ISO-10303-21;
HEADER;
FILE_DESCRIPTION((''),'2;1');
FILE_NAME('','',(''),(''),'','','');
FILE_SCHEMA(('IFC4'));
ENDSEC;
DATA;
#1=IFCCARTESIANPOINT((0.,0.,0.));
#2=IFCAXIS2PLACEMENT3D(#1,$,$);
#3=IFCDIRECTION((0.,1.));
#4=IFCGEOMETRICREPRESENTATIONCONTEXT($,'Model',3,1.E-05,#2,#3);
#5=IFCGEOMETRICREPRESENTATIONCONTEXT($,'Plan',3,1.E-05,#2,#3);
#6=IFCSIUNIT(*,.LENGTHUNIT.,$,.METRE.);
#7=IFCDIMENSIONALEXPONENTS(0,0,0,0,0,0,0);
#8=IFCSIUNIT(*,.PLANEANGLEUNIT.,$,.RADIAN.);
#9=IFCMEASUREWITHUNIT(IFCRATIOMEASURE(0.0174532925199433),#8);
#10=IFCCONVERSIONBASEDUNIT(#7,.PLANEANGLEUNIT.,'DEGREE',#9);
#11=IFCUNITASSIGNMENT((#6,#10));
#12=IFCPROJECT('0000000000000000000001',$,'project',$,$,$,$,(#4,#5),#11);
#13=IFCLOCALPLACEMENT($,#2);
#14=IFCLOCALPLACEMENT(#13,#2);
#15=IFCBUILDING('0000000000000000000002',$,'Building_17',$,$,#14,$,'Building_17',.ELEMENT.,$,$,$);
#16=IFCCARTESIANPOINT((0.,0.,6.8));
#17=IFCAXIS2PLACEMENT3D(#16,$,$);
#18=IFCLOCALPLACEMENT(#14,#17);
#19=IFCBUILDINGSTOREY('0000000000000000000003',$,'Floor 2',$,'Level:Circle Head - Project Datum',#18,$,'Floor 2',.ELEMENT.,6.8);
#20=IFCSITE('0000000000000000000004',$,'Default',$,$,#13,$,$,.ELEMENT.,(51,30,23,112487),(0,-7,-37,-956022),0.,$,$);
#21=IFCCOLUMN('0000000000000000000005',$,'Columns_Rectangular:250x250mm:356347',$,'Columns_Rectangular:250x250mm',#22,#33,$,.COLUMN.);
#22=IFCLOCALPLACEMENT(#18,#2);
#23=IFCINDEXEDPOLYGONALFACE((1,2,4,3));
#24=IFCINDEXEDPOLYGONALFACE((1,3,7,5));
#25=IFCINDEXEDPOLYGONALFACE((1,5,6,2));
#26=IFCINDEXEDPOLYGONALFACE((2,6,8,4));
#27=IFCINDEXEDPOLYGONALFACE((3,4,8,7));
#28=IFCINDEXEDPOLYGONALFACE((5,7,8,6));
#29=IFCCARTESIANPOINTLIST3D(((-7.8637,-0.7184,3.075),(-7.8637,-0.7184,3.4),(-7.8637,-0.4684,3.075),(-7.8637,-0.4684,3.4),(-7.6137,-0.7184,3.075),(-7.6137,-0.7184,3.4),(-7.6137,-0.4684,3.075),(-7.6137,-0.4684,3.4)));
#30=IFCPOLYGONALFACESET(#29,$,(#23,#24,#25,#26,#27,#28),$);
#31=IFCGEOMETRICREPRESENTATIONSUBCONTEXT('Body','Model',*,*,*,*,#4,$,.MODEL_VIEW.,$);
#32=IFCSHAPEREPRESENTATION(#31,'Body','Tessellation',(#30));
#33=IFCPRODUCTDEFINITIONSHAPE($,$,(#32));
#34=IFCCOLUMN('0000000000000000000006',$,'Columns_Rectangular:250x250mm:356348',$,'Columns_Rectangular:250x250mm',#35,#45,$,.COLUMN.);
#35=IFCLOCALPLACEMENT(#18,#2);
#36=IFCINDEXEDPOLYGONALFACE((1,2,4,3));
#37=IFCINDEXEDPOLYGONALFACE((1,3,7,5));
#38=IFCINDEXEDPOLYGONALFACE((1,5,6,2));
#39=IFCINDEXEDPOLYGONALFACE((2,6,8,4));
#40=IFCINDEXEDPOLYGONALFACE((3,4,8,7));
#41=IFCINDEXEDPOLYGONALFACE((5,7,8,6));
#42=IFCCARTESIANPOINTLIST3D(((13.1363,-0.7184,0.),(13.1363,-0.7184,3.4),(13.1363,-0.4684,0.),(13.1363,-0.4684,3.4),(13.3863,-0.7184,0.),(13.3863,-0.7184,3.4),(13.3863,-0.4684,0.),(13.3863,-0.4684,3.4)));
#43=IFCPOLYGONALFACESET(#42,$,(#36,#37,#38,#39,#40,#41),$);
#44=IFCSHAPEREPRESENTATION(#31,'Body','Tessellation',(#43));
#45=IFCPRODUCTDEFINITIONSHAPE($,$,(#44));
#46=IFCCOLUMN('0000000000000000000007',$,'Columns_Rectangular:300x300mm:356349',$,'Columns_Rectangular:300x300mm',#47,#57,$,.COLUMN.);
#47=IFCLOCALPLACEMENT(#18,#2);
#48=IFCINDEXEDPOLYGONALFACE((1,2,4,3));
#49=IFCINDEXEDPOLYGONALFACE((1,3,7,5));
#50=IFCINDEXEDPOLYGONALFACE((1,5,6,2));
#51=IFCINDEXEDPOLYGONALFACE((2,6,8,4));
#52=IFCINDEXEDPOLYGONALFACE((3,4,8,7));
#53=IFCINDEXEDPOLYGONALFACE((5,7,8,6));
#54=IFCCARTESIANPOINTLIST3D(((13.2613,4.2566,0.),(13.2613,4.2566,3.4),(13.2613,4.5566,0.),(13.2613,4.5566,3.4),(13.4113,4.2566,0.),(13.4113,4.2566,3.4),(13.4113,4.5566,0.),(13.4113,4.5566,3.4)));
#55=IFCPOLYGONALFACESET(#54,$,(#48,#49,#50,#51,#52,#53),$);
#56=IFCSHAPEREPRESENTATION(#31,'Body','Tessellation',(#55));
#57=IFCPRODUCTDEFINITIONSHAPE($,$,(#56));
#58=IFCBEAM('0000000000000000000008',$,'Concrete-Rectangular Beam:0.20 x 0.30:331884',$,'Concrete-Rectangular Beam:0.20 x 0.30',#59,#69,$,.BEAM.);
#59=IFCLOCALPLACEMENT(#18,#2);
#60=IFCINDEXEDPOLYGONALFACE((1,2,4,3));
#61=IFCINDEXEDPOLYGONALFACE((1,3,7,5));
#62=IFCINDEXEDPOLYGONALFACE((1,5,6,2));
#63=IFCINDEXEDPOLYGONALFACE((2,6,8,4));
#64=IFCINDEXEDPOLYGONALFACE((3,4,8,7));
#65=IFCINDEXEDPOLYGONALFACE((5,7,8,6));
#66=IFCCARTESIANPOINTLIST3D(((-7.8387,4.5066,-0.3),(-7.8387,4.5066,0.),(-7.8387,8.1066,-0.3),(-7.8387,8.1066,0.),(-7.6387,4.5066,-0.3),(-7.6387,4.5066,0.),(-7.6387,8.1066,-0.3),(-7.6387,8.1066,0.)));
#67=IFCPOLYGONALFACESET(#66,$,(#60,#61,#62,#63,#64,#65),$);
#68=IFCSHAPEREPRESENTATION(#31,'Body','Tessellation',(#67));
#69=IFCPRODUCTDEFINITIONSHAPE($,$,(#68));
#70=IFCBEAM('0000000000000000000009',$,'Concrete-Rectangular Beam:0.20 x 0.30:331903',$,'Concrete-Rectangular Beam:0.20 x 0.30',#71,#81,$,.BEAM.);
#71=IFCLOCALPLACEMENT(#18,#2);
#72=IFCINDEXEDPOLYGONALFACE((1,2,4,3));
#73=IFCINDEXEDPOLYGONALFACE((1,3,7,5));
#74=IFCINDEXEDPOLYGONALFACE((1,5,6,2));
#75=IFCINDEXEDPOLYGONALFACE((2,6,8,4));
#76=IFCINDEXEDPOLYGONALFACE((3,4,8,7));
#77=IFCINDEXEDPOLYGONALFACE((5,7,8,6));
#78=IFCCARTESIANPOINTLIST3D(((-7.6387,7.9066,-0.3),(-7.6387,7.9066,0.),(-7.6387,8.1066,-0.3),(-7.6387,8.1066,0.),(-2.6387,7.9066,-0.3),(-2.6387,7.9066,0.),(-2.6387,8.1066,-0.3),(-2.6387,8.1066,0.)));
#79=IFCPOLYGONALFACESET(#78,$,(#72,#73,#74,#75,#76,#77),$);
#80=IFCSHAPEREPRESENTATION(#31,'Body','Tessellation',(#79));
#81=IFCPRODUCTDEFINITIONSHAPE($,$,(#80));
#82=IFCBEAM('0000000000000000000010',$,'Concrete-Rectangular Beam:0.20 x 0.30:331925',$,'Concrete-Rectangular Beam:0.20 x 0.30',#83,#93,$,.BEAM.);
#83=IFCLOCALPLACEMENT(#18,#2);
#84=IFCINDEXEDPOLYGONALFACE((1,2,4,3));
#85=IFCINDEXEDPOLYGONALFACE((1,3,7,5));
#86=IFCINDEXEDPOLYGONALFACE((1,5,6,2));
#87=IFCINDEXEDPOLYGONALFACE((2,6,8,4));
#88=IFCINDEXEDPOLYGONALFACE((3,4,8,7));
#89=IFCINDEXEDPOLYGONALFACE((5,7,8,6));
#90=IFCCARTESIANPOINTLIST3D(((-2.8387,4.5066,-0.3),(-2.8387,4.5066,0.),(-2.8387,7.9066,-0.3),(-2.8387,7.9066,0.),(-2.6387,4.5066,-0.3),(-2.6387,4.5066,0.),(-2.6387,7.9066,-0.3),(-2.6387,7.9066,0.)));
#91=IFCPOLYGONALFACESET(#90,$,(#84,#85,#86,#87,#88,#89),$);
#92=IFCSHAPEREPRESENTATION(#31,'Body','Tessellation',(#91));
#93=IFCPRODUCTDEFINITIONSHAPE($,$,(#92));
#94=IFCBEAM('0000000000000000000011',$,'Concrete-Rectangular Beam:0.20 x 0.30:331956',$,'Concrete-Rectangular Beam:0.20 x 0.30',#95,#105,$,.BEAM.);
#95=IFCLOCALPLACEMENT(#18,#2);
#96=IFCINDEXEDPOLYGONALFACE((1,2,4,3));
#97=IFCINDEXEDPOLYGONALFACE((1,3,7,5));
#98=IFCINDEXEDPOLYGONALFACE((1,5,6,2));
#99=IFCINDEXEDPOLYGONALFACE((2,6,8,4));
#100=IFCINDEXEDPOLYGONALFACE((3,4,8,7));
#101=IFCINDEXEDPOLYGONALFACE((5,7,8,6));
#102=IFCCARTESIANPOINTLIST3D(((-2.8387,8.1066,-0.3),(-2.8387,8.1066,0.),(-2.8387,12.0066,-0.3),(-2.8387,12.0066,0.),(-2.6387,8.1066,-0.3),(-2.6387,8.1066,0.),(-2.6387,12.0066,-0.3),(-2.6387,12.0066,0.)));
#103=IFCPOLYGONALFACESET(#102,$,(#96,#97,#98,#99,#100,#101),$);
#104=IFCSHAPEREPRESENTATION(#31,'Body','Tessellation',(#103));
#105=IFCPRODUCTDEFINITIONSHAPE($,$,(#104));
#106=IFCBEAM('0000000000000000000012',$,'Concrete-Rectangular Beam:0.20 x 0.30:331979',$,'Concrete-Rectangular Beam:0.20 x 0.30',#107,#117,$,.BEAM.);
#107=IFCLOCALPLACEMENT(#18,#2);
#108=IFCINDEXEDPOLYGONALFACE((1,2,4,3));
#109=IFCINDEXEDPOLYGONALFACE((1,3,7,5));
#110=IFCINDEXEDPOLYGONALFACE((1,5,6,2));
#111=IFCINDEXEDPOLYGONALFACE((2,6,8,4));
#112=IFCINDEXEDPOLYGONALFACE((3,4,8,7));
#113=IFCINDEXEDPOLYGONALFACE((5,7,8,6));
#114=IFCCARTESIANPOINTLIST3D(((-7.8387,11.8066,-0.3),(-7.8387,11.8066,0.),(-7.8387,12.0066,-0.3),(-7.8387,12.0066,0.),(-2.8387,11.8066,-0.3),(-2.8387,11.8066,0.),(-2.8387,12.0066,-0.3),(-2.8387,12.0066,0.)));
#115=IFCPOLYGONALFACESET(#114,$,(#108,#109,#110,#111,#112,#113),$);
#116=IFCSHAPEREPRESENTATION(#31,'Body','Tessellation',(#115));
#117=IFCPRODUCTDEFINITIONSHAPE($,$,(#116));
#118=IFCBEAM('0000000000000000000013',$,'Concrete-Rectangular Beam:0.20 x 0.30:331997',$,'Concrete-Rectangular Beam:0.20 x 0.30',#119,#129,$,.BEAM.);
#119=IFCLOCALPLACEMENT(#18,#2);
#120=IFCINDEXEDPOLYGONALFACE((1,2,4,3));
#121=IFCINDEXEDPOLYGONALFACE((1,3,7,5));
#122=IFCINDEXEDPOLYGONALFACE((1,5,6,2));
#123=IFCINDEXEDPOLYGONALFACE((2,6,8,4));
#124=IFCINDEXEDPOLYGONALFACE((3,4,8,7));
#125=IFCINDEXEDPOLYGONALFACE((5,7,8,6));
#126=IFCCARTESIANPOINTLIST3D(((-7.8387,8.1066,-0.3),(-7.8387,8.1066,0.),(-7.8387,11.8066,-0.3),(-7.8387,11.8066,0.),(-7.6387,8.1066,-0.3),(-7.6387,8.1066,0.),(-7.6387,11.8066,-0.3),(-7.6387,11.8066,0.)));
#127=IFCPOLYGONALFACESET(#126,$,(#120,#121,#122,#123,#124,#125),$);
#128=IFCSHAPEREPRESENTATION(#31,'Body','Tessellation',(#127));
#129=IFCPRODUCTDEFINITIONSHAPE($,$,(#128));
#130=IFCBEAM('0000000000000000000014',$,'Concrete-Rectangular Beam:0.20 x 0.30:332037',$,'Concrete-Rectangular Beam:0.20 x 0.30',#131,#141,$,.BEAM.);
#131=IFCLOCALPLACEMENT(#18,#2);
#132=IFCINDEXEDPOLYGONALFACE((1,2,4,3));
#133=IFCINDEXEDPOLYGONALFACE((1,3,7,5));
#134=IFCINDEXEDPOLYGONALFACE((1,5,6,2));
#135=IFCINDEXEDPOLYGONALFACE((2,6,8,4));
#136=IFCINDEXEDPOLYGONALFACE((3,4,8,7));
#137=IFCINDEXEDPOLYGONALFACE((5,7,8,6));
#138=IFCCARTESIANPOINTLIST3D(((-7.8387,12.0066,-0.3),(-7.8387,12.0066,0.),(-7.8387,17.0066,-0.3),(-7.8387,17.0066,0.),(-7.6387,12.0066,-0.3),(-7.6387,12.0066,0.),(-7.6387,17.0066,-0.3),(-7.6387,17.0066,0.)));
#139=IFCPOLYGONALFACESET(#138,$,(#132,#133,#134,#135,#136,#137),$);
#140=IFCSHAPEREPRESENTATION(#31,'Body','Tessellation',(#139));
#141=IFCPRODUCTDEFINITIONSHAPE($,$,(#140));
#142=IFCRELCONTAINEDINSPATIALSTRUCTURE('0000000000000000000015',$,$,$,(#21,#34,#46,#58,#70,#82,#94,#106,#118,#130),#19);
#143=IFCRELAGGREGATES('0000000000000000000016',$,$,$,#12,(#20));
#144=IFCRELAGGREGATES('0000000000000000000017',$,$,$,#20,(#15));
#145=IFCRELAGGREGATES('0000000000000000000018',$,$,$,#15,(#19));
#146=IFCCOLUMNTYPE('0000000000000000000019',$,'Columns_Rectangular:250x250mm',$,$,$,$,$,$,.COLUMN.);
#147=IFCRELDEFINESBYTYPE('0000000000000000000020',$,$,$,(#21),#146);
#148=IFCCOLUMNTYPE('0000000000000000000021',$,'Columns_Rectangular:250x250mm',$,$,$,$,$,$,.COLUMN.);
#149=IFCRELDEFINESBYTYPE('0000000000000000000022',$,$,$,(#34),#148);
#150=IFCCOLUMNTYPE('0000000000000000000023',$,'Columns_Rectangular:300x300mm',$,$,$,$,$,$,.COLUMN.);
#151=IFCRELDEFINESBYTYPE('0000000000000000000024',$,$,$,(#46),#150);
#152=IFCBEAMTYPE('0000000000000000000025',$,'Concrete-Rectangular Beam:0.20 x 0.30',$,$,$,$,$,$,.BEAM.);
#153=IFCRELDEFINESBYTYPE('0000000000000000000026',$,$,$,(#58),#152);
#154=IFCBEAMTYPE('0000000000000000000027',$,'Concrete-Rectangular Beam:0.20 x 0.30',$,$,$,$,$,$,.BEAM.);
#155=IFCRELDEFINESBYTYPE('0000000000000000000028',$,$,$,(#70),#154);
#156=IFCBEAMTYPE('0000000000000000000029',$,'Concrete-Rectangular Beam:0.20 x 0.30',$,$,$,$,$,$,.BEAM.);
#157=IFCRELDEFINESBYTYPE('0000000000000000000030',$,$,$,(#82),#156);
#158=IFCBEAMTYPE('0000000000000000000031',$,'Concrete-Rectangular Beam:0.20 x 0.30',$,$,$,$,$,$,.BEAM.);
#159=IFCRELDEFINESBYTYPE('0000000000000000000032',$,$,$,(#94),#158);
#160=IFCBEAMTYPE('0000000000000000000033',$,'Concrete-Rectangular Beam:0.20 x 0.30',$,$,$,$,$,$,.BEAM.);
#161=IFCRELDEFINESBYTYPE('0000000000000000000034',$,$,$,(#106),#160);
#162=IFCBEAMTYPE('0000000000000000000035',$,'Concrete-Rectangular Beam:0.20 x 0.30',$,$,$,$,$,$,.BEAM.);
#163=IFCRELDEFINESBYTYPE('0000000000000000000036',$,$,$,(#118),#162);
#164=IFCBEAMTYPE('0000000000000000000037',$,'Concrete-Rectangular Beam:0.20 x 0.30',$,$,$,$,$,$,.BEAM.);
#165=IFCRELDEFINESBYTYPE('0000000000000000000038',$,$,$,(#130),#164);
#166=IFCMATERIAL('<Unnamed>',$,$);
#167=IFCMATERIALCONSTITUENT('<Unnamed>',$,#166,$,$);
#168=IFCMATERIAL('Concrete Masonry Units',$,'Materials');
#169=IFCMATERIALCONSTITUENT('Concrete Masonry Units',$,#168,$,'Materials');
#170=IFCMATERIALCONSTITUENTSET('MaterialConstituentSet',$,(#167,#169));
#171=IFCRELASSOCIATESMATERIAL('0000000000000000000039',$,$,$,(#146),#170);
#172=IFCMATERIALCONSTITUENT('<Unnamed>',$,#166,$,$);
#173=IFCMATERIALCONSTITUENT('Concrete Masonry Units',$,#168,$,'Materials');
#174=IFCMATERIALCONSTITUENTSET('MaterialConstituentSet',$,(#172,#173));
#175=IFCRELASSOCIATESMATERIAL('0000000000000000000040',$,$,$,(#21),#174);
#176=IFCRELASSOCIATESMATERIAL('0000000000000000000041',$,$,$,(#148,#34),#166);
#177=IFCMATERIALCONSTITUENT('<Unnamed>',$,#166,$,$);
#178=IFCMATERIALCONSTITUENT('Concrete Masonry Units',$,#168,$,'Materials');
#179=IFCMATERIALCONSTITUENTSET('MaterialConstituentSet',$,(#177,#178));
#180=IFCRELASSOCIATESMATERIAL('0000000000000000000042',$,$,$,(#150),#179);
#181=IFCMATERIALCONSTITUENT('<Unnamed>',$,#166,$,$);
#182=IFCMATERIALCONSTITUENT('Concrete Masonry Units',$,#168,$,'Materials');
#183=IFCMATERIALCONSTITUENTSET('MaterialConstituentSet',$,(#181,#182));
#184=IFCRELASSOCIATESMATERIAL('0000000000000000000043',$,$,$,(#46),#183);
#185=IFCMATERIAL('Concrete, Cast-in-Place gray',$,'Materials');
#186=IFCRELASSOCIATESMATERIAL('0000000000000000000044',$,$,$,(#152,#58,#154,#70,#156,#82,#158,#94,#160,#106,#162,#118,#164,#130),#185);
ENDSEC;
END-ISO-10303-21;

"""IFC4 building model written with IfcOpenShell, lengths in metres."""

from ifc_helpers import new_model, entity, si_unit, converted_unit, direction, frame, origin, place, context, subcontext, project, spatial, indexed_curve, outline, extrude, source, transform, mapped, material, constituent, constituent_set, type_object, type_shapes, element, save


model = new_model("IFC4")

# Units and contexts
model_context = context("Model", 3, precision=1e-05, world=origin(), true_north=direction((0.0, 1.0)))
plan_context = context("Plan", 3, precision=1e-05, world=origin(), true_north=direction((0.0, 1.0)))
body_context = subcontext(model_context, "Body", "Model", "MODEL_VIEW")
ifc_project = project(units=[si_unit("LENGTHUNIT", "METRE"), converted_unit("PLANEANGLEUNIT", "DEGREE", entity("IfcRatioMeasure", 0.0174532925199433), si_unit("PLANEANGLEUNIT", "RADIAN"), dimensions=[0, 0, 0, 0, 0, 0, 0])], contexts=[model_context, plan_context])

# Site, building, storey
site_placement = place(None, origin())
site = spatial("IfcSite", under=ifc_project, at=site_placement, Name="Default", CompositionType="ELEMENT", RefLatitude=(51, 30, 23, 112487), RefLongitude=(0, -7, -37, -956022), RefElevation=0.0)
building_placement = place(site_placement, origin())
building = spatial("IfcBuilding", under=site, at=building_placement, Name="Building_17", LongName="Building_17", CompositionType="ELEMENT")
storey_placement = place(building_placement, frame((0.0, 0.0, 6.8)))
storey = spatial("IfcBuildingStorey", under=building, at=storey_placement, Name="Floor 2", ObjectType="Level:Circle Head - Project Datum", LongName="Floor 2", CompositionType="ELEMENT", Elevation=6.8)

# Columns
ifc_material_1 = material(Name="<Unnamed>")
ifc_constituent_1 = constituent(ifc_material_1, Name="<Unnamed>")
ifc_material_2 = material(Name="Concrete Masonry Units", Category="Materials")
ifc_constituent_2 = constituent(ifc_material_2, Name="Concrete Masonry Units", Category="Materials")
ifc_constituent_set_1 = constituent_set(constituents=[ifc_constituent_1, ifc_constituent_2], Name="MaterialConstituentSet")
ifc_constituent_3 = constituent(ifc_material_1, Name="<Unnamed>")
ifc_constituent_4 = constituent(ifc_material_2, Name="Concrete Masonry Units", Category="Materials")
ifc_constituent_set_2 = constituent_set(constituents=[ifc_constituent_3, ifc_constituent_4], Name="MaterialConstituentSet")
column_type_1 = type_object("IfcColumnType", Name="Columns_Rectangular:250x250mm", PredefinedType="COLUMN", material=ifc_constituent_set_2)
shared_shape_1 = source(origin(), body_context, "Body", "SweptSolid", [
    extrude(outline(indexed_curve([(-0.125, -0.125), (0.125, -0.125), (0.125, 0.125), (-0.125, 0.125), (-0.125, -0.125)], self_intersect=False)), frame((-7.7387, -0.5934, 9.875), z_axis=(0.0, 0.0, 1.0), x_axis=(0.0, -1.0, 0.0)), (0.0, 0.0, 1.0), 0.325),
])
type_shapes(column_type_1, [shared_shape_1])
column_1_placement = place(storey_placement, frame((0.0, 0.0, -6.8)))
element("IfcColumn", 1, at=column_1_placement, inside=storey, type_object=column_type_1, material=ifc_constituent_set_1, Name="Columns_Rectangular:250x250mm:356347", ObjectType="Columns_Rectangular:250x250mm", PredefinedType="COLUMN", context=body_context, shape_type="MappedRepresentation", body=[
    mapped(shared_shape_1, transform((0.0, 0.0, 0.0), scale=1.0)),
])
column_type_2 = type_object("IfcColumnType", Name="Columns_Rectangular:250x250mm", PredefinedType="COLUMN", material=ifc_material_1)
shared_shape_2 = source(origin(), body_context, "Body", "SweptSolid", [
    extrude(outline(indexed_curve([(-0.125, -0.125), (0.125, -0.125), (0.125, 0.125), (-0.125, 0.125), (-0.125, -0.125)], self_intersect=False)), frame((13.2613, -0.5934, 6.8), z_axis=(0.0, 0.0, 1.0), x_axis=(0.0, -1.0, 0.0)), (0.0, 0.0, 1.0), 3.4),
])
type_shapes(column_type_2, [shared_shape_2])
column_2_placement = place(storey_placement, frame((0.0, 0.0, -6.8)))
element("IfcColumn", 2, at=column_2_placement, inside=storey, type_object=column_type_2, material=ifc_material_1, Name="Columns_Rectangular:250x250mm:356348", ObjectType="Columns_Rectangular:250x250mm", PredefinedType="COLUMN", context=body_context, shape_type="MappedRepresentation", body=[
    mapped(shared_shape_2, transform((0.0, 0.0, 0.0), scale=1.0)),
])
ifc_constituent_5 = constituent(ifc_material_1, Name="<Unnamed>")
ifc_constituent_6 = constituent(ifc_material_2, Name="Concrete Masonry Units", Category="Materials")
ifc_constituent_set_3 = constituent_set(constituents=[ifc_constituent_5, ifc_constituent_6], Name="MaterialConstituentSet")
ifc_constituent_7 = constituent(ifc_material_1, Name="<Unnamed>")
ifc_constituent_8 = constituent(ifc_material_2, Name="Concrete Masonry Units", Category="Materials")
ifc_constituent_set_4 = constituent_set(constituents=[ifc_constituent_7, ifc_constituent_8], Name="MaterialConstituentSet")
column_type_3 = type_object("IfcColumnType", Name="Columns_Rectangular:300x300mm", PredefinedType="COLUMN", material=ifc_constituent_set_4)
shared_shape_3 = source(origin(), body_context, "Body", "SweptSolid", [
    extrude(outline(indexed_curve([(-0.15, -0.075), (0.15, -0.075), (0.15, 0.075), (-0.15, 0.075), (-0.15, -0.075)], self_intersect=False)), frame((13.3363, 4.4066, 6.8), z_axis=(0.0, 0.0, 1.0), x_axis=(0.0, -1.0, 0.0)), (0.0, 0.0, 1.0), 3.4),
])
type_shapes(column_type_3, [shared_shape_3])
column_3_placement = place(storey_placement, frame((0.0, 0.0, -6.8)))
element("IfcColumn", 3, at=column_3_placement, inside=storey, type_object=column_type_3, material=ifc_constituent_set_3, Name="Columns_Rectangular:300x300mm:356349", ObjectType="Columns_Rectangular:300x300mm", PredefinedType="COLUMN", context=body_context, shape_type="MappedRepresentation", body=[
    mapped(shared_shape_3, transform((0.0, 0.0, 0.0), scale=1.0)),
])

# Beams
ifc_material_3 = material(Name="Concrete, Cast-in-Place gray", Category="Materials")
beam_type_1 = type_object("IfcBeamType", Name="Concrete-Rectangular Beam:0.20 x 0.30", PredefinedType="BEAM", material=ifc_material_3)
shared_shape_4 = source(origin(), body_context, "Body", "SweptSolid", [
    extrude(outline(indexed_curve([(-0.1, -0.15), (0.1, -0.15), (0.1, 0.15), (-0.1, 0.15), (-0.1, -0.15)], self_intersect=False)), frame((-7.7387, 4.5066, 6.65), z_axis=(0.0, 1.0, 0.0), x_axis=(-1.0, 0.0, 0.0)), (0.0, 0.0, 1.0), 3.6),
])
type_shapes(beam_type_1, [shared_shape_4])
beam_1_placement = place(storey_placement, frame((0.0, 0.0, -6.8)))
element("IfcBeam", 4, at=beam_1_placement, inside=storey, type_object=beam_type_1, material=ifc_material_3, Name="Concrete-Rectangular Beam:0.20 x 0.30:331884", ObjectType="Concrete-Rectangular Beam:0.20 x 0.30", PredefinedType="BEAM", context=body_context, shape_type="MappedRepresentation", body=[
    mapped(shared_shape_4, transform((0.0, 0.0, 0.0), scale=1.0)),
])
beam_type_2 = type_object("IfcBeamType", Name="Concrete-Rectangular Beam:0.20 x 0.30", PredefinedType="BEAM", material=ifc_material_3)
shared_shape_5 = source(origin(), body_context, "Body", "SweptSolid", [
    extrude(outline(indexed_curve([(-0.15, -0.1), (0.15, -0.1), (0.15, 0.1), (-0.15, 0.1), (-0.15, -0.1)], self_intersect=False)), frame((-7.6387, 8.0066, 6.65), z_axis=(1.0, 0.0, 0.0), x_axis=(0.0, 0.0, -1.0)), (0.0, 0.0, 1.0), 5.0),
])
type_shapes(beam_type_2, [shared_shape_5])
beam_2_placement = place(storey_placement, frame((0.0, 0.0, -6.8)))
element("IfcBeam", 5, at=beam_2_placement, inside=storey, type_object=beam_type_2, material=ifc_material_3, Name="Concrete-Rectangular Beam:0.20 x 0.30:331903", ObjectType="Concrete-Rectangular Beam:0.20 x 0.30", PredefinedType="BEAM", context=body_context, shape_type="MappedRepresentation", body=[
    mapped(shared_shape_5, transform((0.0, 0.0, 0.0), scale=1.0)),
])
beam_type_3 = type_object("IfcBeamType", Name="Concrete-Rectangular Beam:0.20 x 0.30", PredefinedType="BEAM", material=ifc_material_3)
shared_shape_6 = source(origin(), body_context, "Body", "SweptSolid", [
    extrude(outline(indexed_curve([(-0.1, -0.15), (0.1, -0.15), (0.1, 0.15), (-0.1, 0.15), (-0.1, -0.15)], self_intersect=False)), frame((-2.7387, 7.9066, 6.65), z_axis=(0.0, -1.0, 0.0), x_axis=(-1.0, 0.0, 0.0)), (0.0, 0.0, 1.0), 3.4),
])
type_shapes(beam_type_3, [shared_shape_6])
beam_3_placement = place(storey_placement, frame((0.0, 0.0, -6.8)))
element("IfcBeam", 6, at=beam_3_placement, inside=storey, type_object=beam_type_3, material=ifc_material_3, Name="Concrete-Rectangular Beam:0.20 x 0.30:331925", ObjectType="Concrete-Rectangular Beam:0.20 x 0.30", PredefinedType="BEAM", context=body_context, shape_type="MappedRepresentation", body=[
    mapped(shared_shape_6, transform((0.0, 0.0, 0.0), scale=1.0)),
])
beam_type_4 = type_object("IfcBeamType", Name="Concrete-Rectangular Beam:0.20 x 0.30", PredefinedType="BEAM", material=ifc_material_3)
shared_shape_7 = source(origin(), body_context, "Body", "SweptSolid", [
    extrude(outline(indexed_curve([(-0.1, -0.15), (0.1, -0.15), (0.1, 0.15), (-0.1, 0.15), (-0.1, -0.15)], self_intersect=False)), frame((-2.7387, 8.1066, 6.65), z_axis=(0.0, 1.0, 0.0), x_axis=(-1.0, 0.0, 0.0)), (0.0, 0.0, 1.0), 3.9),
])
type_shapes(beam_type_4, [shared_shape_7])
beam_4_placement = place(storey_placement, frame((0.0, 0.0, -6.8)))
element("IfcBeam", 7, at=beam_4_placement, inside=storey, type_object=beam_type_4, material=ifc_material_3, Name="Concrete-Rectangular Beam:0.20 x 0.30:331956", ObjectType="Concrete-Rectangular Beam:0.20 x 0.30", PredefinedType="BEAM", context=body_context, shape_type="MappedRepresentation", body=[
    mapped(shared_shape_7, transform((0.0, 0.0, 0.0), scale=1.0)),
])
beam_type_5 = type_object("IfcBeamType", Name="Concrete-Rectangular Beam:0.20 x 0.30", PredefinedType="BEAM", material=ifc_material_3)
shared_shape_8 = source(origin(), body_context, "Body", "SweptSolid", [
    extrude(outline(indexed_curve([(-0.15, -0.1), (0.15, -0.1), (0.15, 0.1), (-0.15, 0.1), (-0.15, -0.1)], self_intersect=False)), frame((-2.8387, 11.9066, 6.65), z_axis=(-1.0, 0.0, 0.0), x_axis=(0.0, 0.0, -1.0)), (0.0, 0.0, 1.0), 5.0),
])
type_shapes(beam_type_5, [shared_shape_8])
beam_5_placement = place(storey_placement, frame((0.0, 0.0, -6.8)))
element("IfcBeam", 8, at=beam_5_placement, inside=storey, type_object=beam_type_5, material=ifc_material_3, Name="Concrete-Rectangular Beam:0.20 x 0.30:331979", ObjectType="Concrete-Rectangular Beam:0.20 x 0.30", PredefinedType="BEAM", context=body_context, shape_type="MappedRepresentation", body=[
    mapped(shared_shape_8, transform((0.0, 0.0, 0.0), scale=1.0)),
])
beam_type_6 = type_object("IfcBeamType", Name="Concrete-Rectangular Beam:0.20 x 0.30", PredefinedType="BEAM", material=ifc_material_3)
shared_shape_9 = source(origin(), body_context, "Body", "SweptSolid", [
    extrude(outline(indexed_curve([(-0.1, -0.15), (0.1, -0.15), (0.1, 0.15), (-0.1, 0.15), (-0.1, -0.15)], self_intersect=False)), frame((-7.7387, 11.8066, 6.65), z_axis=(0.0, -1.0, 0.0), x_axis=(-1.0, 0.0, 0.0)), (0.0, 0.0, 1.0), 3.7),
])
type_shapes(beam_type_6, [shared_shape_9])
beam_6_placement = place(storey_placement, frame((0.0, 0.0, -6.8)))
element("IfcBeam", 9, at=beam_6_placement, inside=storey, type_object=beam_type_6, material=ifc_material_3, Name="Concrete-Rectangular Beam:0.20 x 0.30:331997", ObjectType="Concrete-Rectangular Beam:0.20 x 0.30", PredefinedType="BEAM", context=body_context, shape_type="MappedRepresentation", body=[
    mapped(shared_shape_9, transform((0.0, 0.0, 0.0), scale=1.0)),
])
beam_type_7 = type_object("IfcBeamType", Name="Concrete-Rectangular Beam:0.20 x 0.30", PredefinedType="BEAM", material=ifc_material_3)
shared_shape_10 = source(origin(), body_context, "Body", "SweptSolid", [
    extrude(outline(indexed_curve([(-0.1, -0.15), (0.1, -0.15), (0.1, 0.15), (-0.1, 0.15), (-0.1, -0.15)], self_intersect=False)), frame((-7.7387, 17.0066, 6.65), z_axis=(0.0, -1.0, 0.0), x_axis=(-1.0, 0.0, 0.0)), (0.0, 0.0, 1.0), 5.0),
])
type_shapes(beam_type_7, [shared_shape_10])
beam_7_placement = place(storey_placement, frame((0.0, 0.0, -6.8)))
element("IfcBeam", 10, at=beam_7_placement, inside=storey, type_object=beam_type_7, material=ifc_material_3, Name="Concrete-Rectangular Beam:0.20 x 0.30:332037", ObjectType="Concrete-Rectangular Beam:0.20 x 0.30", PredefinedType="BEAM", context=body_context, shape_type="MappedRepresentation", body=[
    mapped(shared_shape_10, transform((0.0, 0.0, 0.0), scale=1.0)),
])

save(model, "model.ifc")
